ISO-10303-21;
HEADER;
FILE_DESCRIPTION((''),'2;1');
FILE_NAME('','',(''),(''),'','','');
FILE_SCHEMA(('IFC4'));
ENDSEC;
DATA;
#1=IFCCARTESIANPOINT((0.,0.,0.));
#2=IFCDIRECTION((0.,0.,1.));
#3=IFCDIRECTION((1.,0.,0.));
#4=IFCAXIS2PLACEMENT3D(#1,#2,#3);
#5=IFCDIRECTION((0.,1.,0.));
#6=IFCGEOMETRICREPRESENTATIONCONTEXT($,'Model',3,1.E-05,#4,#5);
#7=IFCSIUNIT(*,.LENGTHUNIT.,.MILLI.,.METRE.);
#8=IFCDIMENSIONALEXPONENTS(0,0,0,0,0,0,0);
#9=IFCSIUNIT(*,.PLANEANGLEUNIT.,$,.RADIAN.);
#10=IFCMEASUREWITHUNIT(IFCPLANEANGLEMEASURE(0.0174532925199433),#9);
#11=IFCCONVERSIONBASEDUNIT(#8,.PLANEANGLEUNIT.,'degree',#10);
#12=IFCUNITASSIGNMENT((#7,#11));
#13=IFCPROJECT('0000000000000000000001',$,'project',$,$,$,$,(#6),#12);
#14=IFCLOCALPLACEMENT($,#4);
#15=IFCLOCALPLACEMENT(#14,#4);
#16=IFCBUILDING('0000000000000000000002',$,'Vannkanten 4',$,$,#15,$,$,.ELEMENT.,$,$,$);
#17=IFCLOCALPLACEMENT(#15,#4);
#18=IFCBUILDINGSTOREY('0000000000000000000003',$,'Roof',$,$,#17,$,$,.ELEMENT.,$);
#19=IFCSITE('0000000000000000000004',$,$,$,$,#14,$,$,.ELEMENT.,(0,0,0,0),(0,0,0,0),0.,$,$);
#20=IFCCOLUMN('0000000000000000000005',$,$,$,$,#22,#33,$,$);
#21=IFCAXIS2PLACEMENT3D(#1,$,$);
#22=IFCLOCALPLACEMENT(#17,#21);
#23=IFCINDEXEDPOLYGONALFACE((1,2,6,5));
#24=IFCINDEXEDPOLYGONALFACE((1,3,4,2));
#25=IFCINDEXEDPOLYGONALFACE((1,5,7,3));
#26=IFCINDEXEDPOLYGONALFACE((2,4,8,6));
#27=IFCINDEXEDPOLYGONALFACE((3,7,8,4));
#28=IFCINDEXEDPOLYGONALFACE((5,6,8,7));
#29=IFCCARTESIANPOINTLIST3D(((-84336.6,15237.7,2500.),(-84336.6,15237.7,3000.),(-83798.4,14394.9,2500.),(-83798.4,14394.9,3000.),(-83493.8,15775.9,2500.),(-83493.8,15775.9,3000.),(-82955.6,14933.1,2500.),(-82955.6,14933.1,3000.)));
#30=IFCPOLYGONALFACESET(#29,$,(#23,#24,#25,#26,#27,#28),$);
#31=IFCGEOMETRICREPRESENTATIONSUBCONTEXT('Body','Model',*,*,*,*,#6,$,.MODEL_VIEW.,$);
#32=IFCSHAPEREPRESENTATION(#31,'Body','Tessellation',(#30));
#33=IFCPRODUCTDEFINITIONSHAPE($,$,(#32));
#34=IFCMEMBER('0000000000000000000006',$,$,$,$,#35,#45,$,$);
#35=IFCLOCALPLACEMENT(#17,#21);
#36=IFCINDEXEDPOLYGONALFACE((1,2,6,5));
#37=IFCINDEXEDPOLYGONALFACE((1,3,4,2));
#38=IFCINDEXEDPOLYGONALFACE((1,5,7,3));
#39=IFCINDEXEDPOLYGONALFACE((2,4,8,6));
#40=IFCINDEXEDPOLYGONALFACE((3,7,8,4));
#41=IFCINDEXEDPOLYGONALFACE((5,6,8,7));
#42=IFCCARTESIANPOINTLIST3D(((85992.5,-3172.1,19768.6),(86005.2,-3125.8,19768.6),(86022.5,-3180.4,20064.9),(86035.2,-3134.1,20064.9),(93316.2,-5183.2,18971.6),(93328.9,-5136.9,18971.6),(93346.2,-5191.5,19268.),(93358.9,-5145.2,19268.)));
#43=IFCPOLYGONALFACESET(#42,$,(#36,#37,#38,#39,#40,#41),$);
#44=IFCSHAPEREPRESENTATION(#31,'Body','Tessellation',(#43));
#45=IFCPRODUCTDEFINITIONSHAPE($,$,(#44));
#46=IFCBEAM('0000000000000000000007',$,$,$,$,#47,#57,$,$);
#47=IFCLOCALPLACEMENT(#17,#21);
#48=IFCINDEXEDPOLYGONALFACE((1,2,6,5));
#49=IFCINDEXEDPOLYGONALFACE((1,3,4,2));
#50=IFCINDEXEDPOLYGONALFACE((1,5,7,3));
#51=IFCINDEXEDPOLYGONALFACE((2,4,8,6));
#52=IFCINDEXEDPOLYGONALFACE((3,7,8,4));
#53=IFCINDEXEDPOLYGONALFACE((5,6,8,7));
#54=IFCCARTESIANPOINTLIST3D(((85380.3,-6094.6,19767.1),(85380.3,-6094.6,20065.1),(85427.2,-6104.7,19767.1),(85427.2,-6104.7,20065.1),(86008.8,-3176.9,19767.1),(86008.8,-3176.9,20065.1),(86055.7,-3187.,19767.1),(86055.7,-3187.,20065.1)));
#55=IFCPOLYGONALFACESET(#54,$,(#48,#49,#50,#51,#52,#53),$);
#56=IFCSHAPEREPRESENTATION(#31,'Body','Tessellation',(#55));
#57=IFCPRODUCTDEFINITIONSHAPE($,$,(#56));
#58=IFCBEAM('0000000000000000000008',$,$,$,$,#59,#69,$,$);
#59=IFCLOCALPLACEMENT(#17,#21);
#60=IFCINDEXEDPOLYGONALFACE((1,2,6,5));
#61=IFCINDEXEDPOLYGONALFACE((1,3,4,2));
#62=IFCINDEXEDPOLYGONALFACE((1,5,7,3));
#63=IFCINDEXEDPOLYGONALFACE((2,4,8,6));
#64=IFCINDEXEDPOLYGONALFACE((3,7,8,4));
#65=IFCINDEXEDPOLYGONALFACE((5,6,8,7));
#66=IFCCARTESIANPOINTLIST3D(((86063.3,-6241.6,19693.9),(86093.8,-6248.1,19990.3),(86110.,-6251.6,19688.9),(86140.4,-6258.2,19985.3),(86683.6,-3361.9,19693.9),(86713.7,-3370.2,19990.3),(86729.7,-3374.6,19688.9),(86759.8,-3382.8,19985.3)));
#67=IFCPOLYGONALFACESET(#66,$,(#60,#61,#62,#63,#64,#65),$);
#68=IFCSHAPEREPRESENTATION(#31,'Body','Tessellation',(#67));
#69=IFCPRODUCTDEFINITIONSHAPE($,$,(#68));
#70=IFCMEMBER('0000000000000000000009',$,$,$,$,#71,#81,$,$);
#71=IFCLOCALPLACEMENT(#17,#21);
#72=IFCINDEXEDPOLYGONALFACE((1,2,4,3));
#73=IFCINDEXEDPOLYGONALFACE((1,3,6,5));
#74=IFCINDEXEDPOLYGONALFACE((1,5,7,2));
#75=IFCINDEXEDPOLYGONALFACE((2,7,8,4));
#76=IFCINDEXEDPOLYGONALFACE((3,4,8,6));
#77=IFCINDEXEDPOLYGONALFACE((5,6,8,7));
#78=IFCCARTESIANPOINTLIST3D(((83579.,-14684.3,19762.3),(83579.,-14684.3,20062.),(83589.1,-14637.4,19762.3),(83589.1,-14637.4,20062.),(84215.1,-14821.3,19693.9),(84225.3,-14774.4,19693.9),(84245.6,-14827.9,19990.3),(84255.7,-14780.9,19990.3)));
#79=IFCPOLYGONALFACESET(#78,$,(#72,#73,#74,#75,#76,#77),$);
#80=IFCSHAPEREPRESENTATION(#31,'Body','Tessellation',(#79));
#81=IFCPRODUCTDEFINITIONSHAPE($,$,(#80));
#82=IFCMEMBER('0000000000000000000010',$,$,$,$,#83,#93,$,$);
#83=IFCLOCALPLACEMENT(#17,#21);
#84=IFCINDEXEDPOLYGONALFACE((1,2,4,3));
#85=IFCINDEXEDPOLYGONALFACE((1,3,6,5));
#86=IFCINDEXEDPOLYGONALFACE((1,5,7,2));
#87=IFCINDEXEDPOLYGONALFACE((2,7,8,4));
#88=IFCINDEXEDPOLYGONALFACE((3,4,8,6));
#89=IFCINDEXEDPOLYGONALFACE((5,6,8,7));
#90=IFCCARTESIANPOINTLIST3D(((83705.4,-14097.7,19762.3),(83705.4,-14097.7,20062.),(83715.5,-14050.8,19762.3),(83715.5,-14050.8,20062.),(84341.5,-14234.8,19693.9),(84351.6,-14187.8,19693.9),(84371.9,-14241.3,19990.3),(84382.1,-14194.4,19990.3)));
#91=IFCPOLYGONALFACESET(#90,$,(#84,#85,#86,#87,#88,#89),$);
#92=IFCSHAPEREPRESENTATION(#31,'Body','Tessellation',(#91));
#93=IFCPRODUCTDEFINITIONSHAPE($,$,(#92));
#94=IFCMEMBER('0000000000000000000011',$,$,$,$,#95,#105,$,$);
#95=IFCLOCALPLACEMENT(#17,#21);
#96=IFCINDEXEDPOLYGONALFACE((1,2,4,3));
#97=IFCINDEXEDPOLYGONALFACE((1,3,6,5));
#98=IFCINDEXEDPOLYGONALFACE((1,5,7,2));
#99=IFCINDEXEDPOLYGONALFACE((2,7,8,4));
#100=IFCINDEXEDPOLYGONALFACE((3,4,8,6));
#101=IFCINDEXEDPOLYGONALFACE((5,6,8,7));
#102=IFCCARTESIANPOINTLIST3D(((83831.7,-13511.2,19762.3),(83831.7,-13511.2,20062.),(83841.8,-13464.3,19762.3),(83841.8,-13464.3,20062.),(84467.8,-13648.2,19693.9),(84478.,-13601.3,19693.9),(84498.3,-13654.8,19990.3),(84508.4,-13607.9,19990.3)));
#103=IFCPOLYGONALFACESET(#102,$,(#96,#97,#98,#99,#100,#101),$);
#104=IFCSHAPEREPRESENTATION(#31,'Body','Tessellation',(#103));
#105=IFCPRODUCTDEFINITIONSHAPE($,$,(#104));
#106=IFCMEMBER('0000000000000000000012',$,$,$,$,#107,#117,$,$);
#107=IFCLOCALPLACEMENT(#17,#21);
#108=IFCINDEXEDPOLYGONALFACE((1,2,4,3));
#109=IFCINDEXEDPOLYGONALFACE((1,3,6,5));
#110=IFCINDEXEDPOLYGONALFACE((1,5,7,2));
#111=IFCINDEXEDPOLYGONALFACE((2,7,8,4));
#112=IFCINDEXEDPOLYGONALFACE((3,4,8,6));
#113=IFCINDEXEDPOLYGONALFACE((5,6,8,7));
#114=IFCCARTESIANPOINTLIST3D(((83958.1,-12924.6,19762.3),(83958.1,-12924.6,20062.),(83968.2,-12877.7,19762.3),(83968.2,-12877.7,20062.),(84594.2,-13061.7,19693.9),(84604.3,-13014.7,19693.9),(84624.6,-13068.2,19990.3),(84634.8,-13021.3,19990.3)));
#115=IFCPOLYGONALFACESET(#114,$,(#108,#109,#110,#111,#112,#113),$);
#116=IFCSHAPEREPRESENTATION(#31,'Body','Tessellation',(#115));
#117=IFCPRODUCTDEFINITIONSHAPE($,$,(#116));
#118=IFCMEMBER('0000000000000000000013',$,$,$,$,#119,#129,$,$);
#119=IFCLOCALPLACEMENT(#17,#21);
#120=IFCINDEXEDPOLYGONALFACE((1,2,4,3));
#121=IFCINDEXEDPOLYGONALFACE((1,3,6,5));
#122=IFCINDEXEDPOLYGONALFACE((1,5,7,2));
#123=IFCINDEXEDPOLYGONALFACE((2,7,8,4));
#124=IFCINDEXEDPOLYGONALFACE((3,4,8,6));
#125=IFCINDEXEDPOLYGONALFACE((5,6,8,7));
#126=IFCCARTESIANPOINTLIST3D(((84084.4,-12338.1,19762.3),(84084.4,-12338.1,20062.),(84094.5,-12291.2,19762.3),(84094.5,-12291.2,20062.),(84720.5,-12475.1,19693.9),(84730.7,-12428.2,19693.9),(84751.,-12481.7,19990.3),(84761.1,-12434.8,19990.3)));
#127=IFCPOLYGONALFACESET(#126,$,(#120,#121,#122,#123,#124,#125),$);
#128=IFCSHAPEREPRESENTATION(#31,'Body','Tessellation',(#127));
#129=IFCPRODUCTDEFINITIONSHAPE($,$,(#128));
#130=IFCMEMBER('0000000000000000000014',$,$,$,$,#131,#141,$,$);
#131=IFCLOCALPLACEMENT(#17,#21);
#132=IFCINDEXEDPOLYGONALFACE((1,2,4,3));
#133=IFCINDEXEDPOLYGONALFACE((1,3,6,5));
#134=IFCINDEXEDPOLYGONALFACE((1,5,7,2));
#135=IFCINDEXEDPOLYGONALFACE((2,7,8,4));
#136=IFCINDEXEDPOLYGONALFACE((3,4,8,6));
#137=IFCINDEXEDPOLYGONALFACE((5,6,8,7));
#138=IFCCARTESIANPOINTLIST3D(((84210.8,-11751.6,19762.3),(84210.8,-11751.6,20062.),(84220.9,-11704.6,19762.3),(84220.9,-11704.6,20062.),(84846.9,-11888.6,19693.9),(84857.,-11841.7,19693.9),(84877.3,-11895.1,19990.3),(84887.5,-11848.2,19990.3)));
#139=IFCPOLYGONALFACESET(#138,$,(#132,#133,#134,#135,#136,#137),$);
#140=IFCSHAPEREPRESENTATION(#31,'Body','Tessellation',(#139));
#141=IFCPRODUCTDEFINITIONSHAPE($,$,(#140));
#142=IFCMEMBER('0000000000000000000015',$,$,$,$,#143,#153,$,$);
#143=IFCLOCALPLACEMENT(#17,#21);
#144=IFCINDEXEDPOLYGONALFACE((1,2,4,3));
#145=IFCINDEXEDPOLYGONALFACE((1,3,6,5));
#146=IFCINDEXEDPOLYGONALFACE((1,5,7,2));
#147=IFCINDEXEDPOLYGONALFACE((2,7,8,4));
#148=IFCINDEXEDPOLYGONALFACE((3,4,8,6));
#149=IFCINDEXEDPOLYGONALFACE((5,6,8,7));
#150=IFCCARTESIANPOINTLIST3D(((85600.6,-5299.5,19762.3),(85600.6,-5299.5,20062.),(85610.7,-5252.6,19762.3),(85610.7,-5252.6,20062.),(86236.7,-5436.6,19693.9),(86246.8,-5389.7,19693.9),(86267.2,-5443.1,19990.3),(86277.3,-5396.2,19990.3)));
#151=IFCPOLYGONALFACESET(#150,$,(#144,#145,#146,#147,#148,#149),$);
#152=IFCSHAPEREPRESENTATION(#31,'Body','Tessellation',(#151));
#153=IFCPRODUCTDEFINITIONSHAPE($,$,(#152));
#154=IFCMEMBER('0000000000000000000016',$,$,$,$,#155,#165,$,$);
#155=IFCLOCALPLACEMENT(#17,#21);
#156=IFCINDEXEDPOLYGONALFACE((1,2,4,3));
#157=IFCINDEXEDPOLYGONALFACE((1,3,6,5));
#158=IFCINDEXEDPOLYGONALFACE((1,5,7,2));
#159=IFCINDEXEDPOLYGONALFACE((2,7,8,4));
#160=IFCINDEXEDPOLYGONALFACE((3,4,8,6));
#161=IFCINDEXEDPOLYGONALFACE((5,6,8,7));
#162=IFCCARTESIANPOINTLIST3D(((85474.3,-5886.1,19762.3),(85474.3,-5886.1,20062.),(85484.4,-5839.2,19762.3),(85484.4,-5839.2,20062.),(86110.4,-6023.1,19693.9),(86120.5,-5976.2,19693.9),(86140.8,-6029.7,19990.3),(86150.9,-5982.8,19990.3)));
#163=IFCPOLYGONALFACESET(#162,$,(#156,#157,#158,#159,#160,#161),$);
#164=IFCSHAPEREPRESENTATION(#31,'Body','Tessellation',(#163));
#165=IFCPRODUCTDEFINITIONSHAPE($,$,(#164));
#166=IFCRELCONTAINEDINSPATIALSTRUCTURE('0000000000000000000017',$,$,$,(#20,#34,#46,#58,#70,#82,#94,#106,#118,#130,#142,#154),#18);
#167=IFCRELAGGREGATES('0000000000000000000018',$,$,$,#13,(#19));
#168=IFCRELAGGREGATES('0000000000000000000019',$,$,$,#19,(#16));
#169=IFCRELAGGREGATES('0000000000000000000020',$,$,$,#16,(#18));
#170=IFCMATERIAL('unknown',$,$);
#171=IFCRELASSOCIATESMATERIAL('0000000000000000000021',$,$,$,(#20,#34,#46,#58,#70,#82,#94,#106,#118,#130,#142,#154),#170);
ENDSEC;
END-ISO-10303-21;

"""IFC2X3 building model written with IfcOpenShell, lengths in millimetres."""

from ifc_helpers import new_model, entity, si_unit, converted_unit, direction, frame, origin_with_axes, place, context, subcontext, project, spatial, polyline, segment, composite_curve, outline, extrude, clip, halfspace, material, element, save


model = new_model("IFC2X3")

# Units and contexts
model_context = context("Model", 3, precision=1e-05, world=origin_with_axes(), true_north=direction((0.0, 1.0, 0.0)))
body_context = subcontext(model_context, "Body", "Model", "MODEL_VIEW")
ifc_project = project(units=[si_unit("LENGTHUNIT", "METRE", prefix="MILLI"), converted_unit("PLANEANGLEUNIT", "degree", entity("IfcPlaneAngleMeasure", 0.0174532925199433), si_unit("PLANEANGLEUNIT", "RADIAN"), dimensions=[0, 0, 0, 0, 0, 0, 0])], contexts=[model_context])

# Site, building, storey
site_placement = place(None, origin_with_axes())
site = spatial("IfcSite", under=ifc_project, at=site_placement, CompositionType="ELEMENT", RefLatitude=(0, 0, 0, 0), RefLongitude=(0, 0, 0, 0), RefElevation=0.0)
building_placement = place(site_placement, origin_with_axes())
building = spatial("IfcBuilding", under=site, at=building_placement, Name="Vannkanten 4", CompositionType="ELEMENT")
storey_placement = place(building_placement, origin_with_axes())
storey = spatial("IfcBuildingStorey", under=building, at=storey_placement, Name="Roof", CompositionType="ELEMENT")

# Column
ifc_material = material(Name="unknown")
column_placement = place(storey_placement, frame((-83646.1, 15085.4, 2500.0), z_axis=(0.0, 0.0, 1.0), x_axis=(-0.538213, 0.842809, 0.0)))
element("IfcColumn", 1, at=column_placement, inside=storey, material=ifc_material, context=body_context, shape_type="SweptSolid", body=[
    extrude(outline(composite_curve([segment(polyline([(-500.0, -500.0), (-500.0, 500.0), (500.0, 500.0), (500.0, -500.0), (-500.0, -500.0)]), True, "CONTINUOUS")], self_intersect=False)), frame((0.0, 0.0, 0.0), z_axis=(0.0, 0.0, 1.0), x_axis=(1.0, 0.0, 0.0)), (0.0, 0.0, 1.0), 500.0),
])

# Member
member_1_placement = place(storey_placement, frame((86013.9, -3153.1, 19916.8), z_axis=(0.959037, -0.263355, -0.104367), x_axis=(0.264801, 0.964303, 0.0)))
element("IfcMember", 2, at=member_1_placement, inside=storey, material=ifc_material, context=body_context, shape_type="SweptSolid", body=[
    extrude(outline(composite_curve([segment(polyline([(-24.0, -149.0), (-24.0, 149.0), (24.0, 149.0), (24.0, -149.0), (-24.0, -149.0)]), True, "CONTINUOUS")], self_intersect=False)), frame((0.0, 0.0, 0.0), z_axis=(0.0, 0.0, 1.0), x_axis=(1.0, 0.0, 0.0)), (0.0, 0.0, 1.0), 7636.4),
])

# Beams
beam_1_placement = place(storey_placement, frame((85403.7, -6099.6, 19916.1), z_axis=(0.210582, 0.977576, 0.0), x_axis=(-0.977576, 0.210582, 0.0)))
element("IfcBeam", 3, at=beam_1_placement, inside=storey, material=ifc_material, context=body_context, shape_type="SweptSolid", body=[
    extrude(outline(composite_curve([segment(polyline([(-24.0, -149.0), (-24.0, 149.0), (24.0, 149.0), (24.0, -149.0), (-24.0, -149.0)]), True, "CONTINUOUS")], self_intersect=False)), frame((0.0, 0.0, 0.0), z_axis=(0.0, 0.0, 1.0), x_axis=(1.0, 0.0, 0.0)), (0.0, 0.0, 1.0), 2984.5),
])
beam_2_placement = place(storey_placement, frame((86101.9, -6249.9, 19839.6), z_axis=(0.210582, 0.977576, 0.0), x_axis=(-0.972221, 0.209428, 0.104528)))
element("IfcBeam", 4, at=beam_2_placement, inside=storey, material=ifc_material, context=body_context, shape_type="Clipping", body=[
    clip(extrude(outline(composite_curve([segment(polyline([(-24.0, -149.0), (-24.0, 149.0), (24.0, 149.0), (24.0, -149.0), (-24.0, -149.0)]), True, "CONTINUOUS")], self_intersect=False)), frame((0.0, 0.0, 0.0), z_axis=(0.0, 0.0, 1.0), x_axis=(1.0, 0.0, 0.0)), (0.0, 0.0, 1.0), 4418.6), halfspace(frame((-24.0, -149.0, 2943.1), z_axis=(0.055493, -0.005833, -0.998442), x_axis=(-0.998459, 0.0, -0.055494)), True)),
])

# Members
member_2_placement = place(storey_placement, frame((84235.4, -14801.1, 19842.1), z_axis=(-0.972221, 0.209428, 0.104528), x_axis=(-0.210582, -0.977576, 0.0)))
element("IfcMember", 5, at=member_2_placement, inside=storey, material=ifc_material, context=body_context, shape_type="Clipping", body=[
    clip(extrude(outline(composite_curve([segment(polyline([(-24.0, -149.0), (-24.0, 149.0), (24.0, 149.0), (24.0, -149.0), (-24.0, -149.0)]), True, "CONTINUOUS")], self_intersect=False)), frame((0.0, 0.0, 0.0), z_axis=(0.0, 0.0, 1.0), x_axis=(1.0, 0.0, 0.0)), (0.0, 0.0, 1.0), 1028.4), halfspace(frame((-24.0, -149.0, 654.3), z_axis=(0.0, 0.104528, -0.994522), x_axis=(0.0, -0.994522, -0.104528)), True)),
])
member_3_placement = place(storey_placement, frame((84361.8, -14214.6, 19842.1), z_axis=(-0.972221, 0.209428, 0.104528), x_axis=(-0.210582, -0.977576, 0.0)))
element("IfcMember", 6, at=member_3_placement, inside=storey, material=ifc_material, context=body_context, shape_type="Clipping", body=[
    clip(extrude(outline(composite_curve([segment(polyline([(-24.0, -149.0), (-24.0, 149.0), (24.0, 149.0), (24.0, -149.0), (-24.0, -149.0)]), True, "CONTINUOUS")], self_intersect=False)), frame((0.0, 0.0, 0.0), z_axis=(0.0, 0.0, 1.0), x_axis=(1.0, 0.0, 0.0)), (0.0, 0.0, 1.0), 1028.4), halfspace(frame((-24.0, -149.0, 654.3), z_axis=(0.0, 0.104528, -0.994522), x_axis=(0.0, -0.994522, -0.104528)), True)),
])
member_4_placement = place(storey_placement, frame((84488.1, -13628.0, 19842.1), z_axis=(-0.972221, 0.209428, 0.104528), x_axis=(-0.210582, -0.977576, 0.0)))
element("IfcMember", 7, at=member_4_placement, inside=storey, material=ifc_material, context=body_context, shape_type="Clipping", body=[
    clip(extrude(outline(composite_curve([segment(polyline([(-24.0, -149.0), (-24.0, 149.0), (24.0, 149.0), (24.0, -149.0), (-24.0, -149.0)]), True, "CONTINUOUS")], self_intersect=False)), frame((0.0, 0.0, 0.0), z_axis=(0.0, 0.0, 1.0), x_axis=(1.0, 0.0, 0.0)), (0.0, 0.0, 1.0), 1028.4), halfspace(frame((-24.0, -149.0, 654.3), z_axis=(0.0, 0.104528, -0.994522), x_axis=(0.0, -0.994522, -0.104528)), True)),
])
member_5_placement = place(storey_placement, frame((84614.5, -13041.5, 19842.1), z_axis=(-0.972221, 0.209428, 0.104528), x_axis=(-0.210582, -0.977576, 0.0)))
element("IfcMember", 8, at=member_5_placement, inside=storey, material=ifc_material, context=body_context, shape_type="Clipping", body=[
    clip(extrude(outline(composite_curve([segment(polyline([(-24.0, -149.0), (-24.0, 149.0), (24.0, 149.0), (24.0, -149.0), (-24.0, -149.0)]), True, "CONTINUOUS")], self_intersect=False)), frame((0.0, 0.0, 0.0), z_axis=(0.0, 0.0, 1.0), x_axis=(1.0, 0.0, 0.0)), (0.0, 0.0, 1.0), 1028.4), halfspace(frame((-24.0, -149.0, 654.3), z_axis=(0.0, 0.104528, -0.994522), x_axis=(0.0, -0.994522, -0.104528)), True)),
])
member_6_placement = place(storey_placement, frame((84740.8, -12454.9, 19842.1), z_axis=(-0.972221, 0.209428, 0.104528), x_axis=(-0.210582, -0.977576, 0.0)))
element("IfcMember", 9, at=member_6_placement, inside=storey, material=ifc_material, context=body_context, shape_type="Clipping", body=[
    clip(extrude(outline(composite_curve([segment(polyline([(-24.0, -149.0), (-24.0, 149.0), (24.0, 149.0), (24.0, -149.0), (-24.0, -149.0)]), True, "CONTINUOUS")], self_intersect=False)), frame((0.0, 0.0, 0.0), z_axis=(0.0, 0.0, 1.0), x_axis=(1.0, 0.0, 0.0)), (0.0, 0.0, 1.0), 1028.4), halfspace(frame((-24.0, -149.0, 654.3), z_axis=(0.0, 0.104528, -0.994522), x_axis=(0.0, -0.994522, -0.104528)), True)),
])
member_7_placement = place(storey_placement, frame((84867.2, -11868.4, 19842.1), z_axis=(-0.972221, 0.209428, 0.104528), x_axis=(-0.210582, -0.977576, 0.0)))
element("IfcMember", 10, at=member_7_placement, inside=storey, material=ifc_material, context=body_context, shape_type="Clipping", body=[
    clip(extrude(outline(composite_curve([segment(polyline([(-24.0, -149.0), (-24.0, 149.0), (24.0, 149.0), (24.0, -149.0), (-24.0, -149.0)]), True, "CONTINUOUS")], self_intersect=False)), frame((0.0, 0.0, 0.0), z_axis=(0.0, 0.0, 1.0), x_axis=(1.0, 0.0, 0.0)), (0.0, 0.0, 1.0), 1028.4), halfspace(frame((-24.0, -149.0, 654.3), z_axis=(0.0, 0.104528, -0.994522), x_axis=(0.0, -0.994522, -0.104528)), True)),
])
member_8_placement = place(storey_placement, frame((86257.0, -5416.4, 19842.1), z_axis=(-0.972221, 0.209428, 0.104528), x_axis=(-0.210582, -0.977576, 0.0)))
element("IfcMember", 11, at=member_8_placement, inside=storey, material=ifc_material, context=body_context, shape_type="Clipping", body=[
    clip(extrude(outline(composite_curve([segment(polyline([(-24.0, -149.0), (-24.0, 149.0), (24.0, 149.0), (24.0, -149.0), (-24.0, -149.0)]), True, "CONTINUOUS")], self_intersect=False)), frame((0.0, 0.0, 0.0), z_axis=(0.0, 0.0, 1.0), x_axis=(1.0, 0.0, 0.0)), (0.0, 0.0, 1.0), 1028.4), halfspace(frame((-24.0, -149.0, 654.3), z_axis=(0.0, 0.104528, -0.994522), x_axis=(0.0, -0.994522, -0.104528)), True)),
])
member_9_placement = place(storey_placement, frame((86130.7, -6002.9, 19842.1), z_axis=(-0.972221, 0.209428, 0.104528), x_axis=(-0.210582, -0.977576, 0.0)))
element("IfcMember", 12, at=member_9_placement, inside=storey, material=ifc_material, context=body_context, shape_type="Clipping", body=[
    clip(extrude(outline(composite_curve([segment(polyline([(-24.0, -149.0), (-24.0, 149.0), (24.0, 149.0), (24.0, -149.0), (-24.0, -149.0)]), True, "CONTINUOUS")], self_intersect=False)), frame((0.0, 0.0, 0.0), z_axis=(0.0, 0.0, 1.0), x_axis=(1.0, 0.0, 0.0)), (0.0, 0.0, 1.0), 1028.4), halfspace(frame((-24.0, -149.0, 654.3), z_axis=(0.0, 0.104528, -0.994522), x_axis=(0.0, -0.994522, -0.104528)), True)),
])

save(model, "model.ifc")
